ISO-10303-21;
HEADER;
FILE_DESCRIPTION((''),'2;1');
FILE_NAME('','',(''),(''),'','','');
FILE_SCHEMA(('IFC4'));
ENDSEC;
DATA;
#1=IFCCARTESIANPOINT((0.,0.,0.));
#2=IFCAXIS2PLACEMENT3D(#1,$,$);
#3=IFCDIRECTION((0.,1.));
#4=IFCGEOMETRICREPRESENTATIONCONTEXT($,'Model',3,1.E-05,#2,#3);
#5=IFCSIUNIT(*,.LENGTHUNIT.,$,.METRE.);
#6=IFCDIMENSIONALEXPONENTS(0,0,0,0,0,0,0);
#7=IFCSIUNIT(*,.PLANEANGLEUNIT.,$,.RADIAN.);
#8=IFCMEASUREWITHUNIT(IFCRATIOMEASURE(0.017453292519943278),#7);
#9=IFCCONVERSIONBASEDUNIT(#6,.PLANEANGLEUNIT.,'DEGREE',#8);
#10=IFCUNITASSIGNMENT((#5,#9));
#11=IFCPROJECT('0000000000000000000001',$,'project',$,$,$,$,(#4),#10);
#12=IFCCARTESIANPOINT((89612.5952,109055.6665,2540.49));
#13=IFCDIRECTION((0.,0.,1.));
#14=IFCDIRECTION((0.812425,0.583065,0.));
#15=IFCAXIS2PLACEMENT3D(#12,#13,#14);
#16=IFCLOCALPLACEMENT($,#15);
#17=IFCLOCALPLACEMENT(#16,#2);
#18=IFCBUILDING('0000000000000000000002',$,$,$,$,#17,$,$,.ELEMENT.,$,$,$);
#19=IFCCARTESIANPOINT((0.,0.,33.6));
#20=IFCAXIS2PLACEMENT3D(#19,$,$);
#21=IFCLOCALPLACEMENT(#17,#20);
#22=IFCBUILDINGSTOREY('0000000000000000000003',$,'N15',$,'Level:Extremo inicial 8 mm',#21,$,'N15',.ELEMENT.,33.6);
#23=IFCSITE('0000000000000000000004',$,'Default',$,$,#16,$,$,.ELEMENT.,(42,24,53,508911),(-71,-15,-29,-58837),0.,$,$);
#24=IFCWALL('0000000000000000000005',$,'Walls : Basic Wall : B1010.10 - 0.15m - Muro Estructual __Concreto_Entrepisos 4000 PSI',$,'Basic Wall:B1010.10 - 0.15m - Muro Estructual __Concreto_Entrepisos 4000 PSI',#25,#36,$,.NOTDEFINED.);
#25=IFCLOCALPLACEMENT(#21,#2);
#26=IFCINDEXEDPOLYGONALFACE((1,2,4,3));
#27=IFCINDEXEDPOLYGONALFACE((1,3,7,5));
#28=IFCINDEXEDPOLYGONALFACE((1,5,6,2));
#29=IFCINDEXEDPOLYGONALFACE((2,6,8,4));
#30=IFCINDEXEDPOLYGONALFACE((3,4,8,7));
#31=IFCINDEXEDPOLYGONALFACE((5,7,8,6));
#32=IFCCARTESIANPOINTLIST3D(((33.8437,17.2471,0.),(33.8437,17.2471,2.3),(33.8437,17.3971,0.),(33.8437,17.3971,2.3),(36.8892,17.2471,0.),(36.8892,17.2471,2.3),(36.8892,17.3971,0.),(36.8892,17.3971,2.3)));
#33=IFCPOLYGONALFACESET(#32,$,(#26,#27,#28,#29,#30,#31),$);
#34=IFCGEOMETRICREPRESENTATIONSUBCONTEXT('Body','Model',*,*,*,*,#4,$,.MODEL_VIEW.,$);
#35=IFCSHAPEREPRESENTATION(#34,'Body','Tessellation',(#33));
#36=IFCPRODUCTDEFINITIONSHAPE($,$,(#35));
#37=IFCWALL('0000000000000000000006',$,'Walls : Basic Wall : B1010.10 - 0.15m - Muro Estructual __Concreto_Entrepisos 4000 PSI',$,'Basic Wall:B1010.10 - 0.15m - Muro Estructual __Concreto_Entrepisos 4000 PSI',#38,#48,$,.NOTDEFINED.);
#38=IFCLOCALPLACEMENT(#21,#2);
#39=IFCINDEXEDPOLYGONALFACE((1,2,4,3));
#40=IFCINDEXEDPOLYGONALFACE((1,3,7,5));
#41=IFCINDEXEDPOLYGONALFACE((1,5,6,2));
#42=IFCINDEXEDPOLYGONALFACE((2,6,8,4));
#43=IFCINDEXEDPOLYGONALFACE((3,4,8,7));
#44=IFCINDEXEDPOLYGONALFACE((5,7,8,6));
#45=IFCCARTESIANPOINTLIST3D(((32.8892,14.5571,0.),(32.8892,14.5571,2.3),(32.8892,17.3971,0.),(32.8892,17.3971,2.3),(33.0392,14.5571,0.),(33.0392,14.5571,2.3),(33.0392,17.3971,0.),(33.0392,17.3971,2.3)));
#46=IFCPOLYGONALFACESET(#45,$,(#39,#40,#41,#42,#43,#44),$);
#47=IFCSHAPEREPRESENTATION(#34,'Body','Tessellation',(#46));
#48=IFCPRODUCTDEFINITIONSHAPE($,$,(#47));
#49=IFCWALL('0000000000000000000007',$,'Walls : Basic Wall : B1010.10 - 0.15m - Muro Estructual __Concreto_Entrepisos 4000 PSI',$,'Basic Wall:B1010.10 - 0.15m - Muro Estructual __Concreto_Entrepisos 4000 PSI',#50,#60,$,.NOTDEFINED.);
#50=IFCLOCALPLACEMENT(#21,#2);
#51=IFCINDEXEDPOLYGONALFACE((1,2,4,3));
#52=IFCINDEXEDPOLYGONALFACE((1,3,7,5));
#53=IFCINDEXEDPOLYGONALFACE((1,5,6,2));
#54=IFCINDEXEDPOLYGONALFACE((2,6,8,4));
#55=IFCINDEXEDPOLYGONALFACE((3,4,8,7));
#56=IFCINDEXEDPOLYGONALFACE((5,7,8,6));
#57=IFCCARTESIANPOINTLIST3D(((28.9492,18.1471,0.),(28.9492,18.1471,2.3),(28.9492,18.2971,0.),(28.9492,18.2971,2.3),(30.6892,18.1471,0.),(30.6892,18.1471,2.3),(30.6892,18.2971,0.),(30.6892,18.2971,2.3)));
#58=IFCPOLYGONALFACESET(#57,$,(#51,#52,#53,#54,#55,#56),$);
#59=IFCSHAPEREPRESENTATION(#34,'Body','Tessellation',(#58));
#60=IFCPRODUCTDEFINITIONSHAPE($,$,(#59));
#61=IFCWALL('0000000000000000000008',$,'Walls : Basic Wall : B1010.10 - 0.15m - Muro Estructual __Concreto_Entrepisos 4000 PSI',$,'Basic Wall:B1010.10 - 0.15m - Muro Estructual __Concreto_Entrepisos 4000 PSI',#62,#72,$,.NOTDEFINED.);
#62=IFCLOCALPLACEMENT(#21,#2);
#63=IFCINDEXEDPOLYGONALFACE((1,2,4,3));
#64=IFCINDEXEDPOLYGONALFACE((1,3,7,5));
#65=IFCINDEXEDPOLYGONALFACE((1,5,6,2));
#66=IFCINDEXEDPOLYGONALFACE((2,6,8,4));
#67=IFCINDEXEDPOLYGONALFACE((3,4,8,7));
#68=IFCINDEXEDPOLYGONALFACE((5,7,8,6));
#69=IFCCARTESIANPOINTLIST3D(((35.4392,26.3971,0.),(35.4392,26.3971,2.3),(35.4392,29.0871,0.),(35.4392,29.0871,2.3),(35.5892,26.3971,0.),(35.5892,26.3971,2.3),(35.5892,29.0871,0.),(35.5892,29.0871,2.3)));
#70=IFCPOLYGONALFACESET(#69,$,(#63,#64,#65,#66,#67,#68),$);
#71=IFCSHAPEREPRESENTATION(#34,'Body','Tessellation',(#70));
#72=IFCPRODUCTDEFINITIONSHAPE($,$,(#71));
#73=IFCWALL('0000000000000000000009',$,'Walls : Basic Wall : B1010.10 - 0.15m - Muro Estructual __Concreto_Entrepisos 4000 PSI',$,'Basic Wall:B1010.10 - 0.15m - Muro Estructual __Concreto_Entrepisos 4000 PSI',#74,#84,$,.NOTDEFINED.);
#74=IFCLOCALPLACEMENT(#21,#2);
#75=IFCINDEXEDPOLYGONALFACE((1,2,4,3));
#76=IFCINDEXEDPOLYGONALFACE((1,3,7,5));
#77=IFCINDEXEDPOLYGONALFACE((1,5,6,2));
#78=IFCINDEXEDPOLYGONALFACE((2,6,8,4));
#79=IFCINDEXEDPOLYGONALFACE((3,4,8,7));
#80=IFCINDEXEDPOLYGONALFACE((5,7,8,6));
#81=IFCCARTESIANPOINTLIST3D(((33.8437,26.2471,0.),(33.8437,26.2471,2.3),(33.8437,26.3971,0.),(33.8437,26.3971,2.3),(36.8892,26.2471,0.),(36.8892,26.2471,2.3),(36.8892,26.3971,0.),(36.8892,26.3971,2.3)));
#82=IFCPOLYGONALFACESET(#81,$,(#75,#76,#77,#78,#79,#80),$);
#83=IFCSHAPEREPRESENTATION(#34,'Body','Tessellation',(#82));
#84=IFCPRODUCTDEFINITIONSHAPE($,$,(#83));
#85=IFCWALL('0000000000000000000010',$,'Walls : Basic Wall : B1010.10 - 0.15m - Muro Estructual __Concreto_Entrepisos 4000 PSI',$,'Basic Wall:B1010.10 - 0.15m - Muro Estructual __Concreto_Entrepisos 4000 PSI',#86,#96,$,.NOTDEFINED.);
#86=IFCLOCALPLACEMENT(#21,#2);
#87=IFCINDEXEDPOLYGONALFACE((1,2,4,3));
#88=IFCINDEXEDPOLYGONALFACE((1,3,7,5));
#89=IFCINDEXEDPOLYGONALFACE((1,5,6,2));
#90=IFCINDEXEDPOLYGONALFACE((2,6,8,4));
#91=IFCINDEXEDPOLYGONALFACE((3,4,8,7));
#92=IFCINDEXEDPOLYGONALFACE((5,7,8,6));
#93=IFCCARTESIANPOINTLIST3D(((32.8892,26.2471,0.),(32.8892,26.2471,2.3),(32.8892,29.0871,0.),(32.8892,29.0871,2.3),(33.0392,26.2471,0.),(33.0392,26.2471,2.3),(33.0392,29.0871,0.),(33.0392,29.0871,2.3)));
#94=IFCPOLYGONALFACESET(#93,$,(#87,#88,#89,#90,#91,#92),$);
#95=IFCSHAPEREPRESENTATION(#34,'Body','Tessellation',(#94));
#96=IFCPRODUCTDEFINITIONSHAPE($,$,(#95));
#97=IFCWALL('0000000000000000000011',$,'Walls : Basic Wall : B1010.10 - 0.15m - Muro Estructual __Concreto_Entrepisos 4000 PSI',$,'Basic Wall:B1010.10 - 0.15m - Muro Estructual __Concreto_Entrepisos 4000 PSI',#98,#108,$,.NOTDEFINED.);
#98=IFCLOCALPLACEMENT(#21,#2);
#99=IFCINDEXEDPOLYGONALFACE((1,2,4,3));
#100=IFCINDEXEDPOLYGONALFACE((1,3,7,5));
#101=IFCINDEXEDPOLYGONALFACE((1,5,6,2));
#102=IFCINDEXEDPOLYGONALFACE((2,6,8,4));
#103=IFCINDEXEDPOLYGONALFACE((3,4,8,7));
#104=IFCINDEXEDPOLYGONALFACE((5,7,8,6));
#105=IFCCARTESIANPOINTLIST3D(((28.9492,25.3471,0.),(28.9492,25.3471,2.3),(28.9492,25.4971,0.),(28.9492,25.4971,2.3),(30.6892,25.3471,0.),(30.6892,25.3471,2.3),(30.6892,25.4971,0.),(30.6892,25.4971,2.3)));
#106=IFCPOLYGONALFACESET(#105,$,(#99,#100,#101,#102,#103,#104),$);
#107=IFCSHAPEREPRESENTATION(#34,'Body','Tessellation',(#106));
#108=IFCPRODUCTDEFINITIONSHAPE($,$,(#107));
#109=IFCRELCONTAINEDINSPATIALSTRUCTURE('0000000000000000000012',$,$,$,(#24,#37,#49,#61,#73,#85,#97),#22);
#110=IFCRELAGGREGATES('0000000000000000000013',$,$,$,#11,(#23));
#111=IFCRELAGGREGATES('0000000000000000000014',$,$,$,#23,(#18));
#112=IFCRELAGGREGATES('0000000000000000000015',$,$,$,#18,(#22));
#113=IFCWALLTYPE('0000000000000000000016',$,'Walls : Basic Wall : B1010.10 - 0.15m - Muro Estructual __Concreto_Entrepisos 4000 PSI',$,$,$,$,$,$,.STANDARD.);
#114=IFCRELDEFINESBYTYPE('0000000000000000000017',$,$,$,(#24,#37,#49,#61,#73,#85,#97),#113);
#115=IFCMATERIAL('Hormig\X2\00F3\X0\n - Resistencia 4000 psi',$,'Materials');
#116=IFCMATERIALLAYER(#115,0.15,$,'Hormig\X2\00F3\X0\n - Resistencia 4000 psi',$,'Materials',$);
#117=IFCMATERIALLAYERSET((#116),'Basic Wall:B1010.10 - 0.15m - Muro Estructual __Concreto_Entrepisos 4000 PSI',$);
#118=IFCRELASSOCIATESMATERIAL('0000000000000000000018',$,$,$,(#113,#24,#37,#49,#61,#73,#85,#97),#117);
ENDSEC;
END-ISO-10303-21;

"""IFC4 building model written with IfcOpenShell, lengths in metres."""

from ifc_helpers import new_model, entity, si_unit, converted_unit, direction, frame, frame_2d, origin, place, context, subcontext, project, spatial, rectangle, extrude, material, layer, layer_set, layer_usage, type_object, element, save


model = new_model("IFC4")

# Units and contexts
model_context = context("Model", 3, precision=1e-05, world=origin(), true_north=direction((0.0, 1.0)))
body_context = subcontext(model_context, "Body", "Model", "MODEL_VIEW")
ifc_project = project(units=[si_unit("LENGTHUNIT", "METRE"), converted_unit("PLANEANGLEUNIT", "DEGREE", entity("IfcRatioMeasure", 0.017453292519943278), si_unit("PLANEANGLEUNIT", "RADIAN"), dimensions=[0, 0, 0, 0, 0, 0, 0])], contexts=[model_context])

# Site, building, storey
site_placement = place(None, frame((89612.5952, 109055.6665, 2540.49), z_axis=(0.0, 0.0, 1.0), x_axis=(0.812425, 0.583065, 0.0)))
site = spatial("IfcSite", under=ifc_project, at=site_placement, Name="Default", CompositionType="ELEMENT", RefLatitude=(42, 24, 53, 508911), RefLongitude=(-71, -15, -29, -58837), RefElevation=0.0)
building_placement = place(site_placement, origin())
building = spatial("IfcBuilding", under=site, at=building_placement, CompositionType="ELEMENT")
storey_placement = place(building_placement, frame((0.0, 0.0, 33.6)))
storey = spatial("IfcBuildingStorey", under=building, at=storey_placement, Name="N15", ObjectType="Level:Extremo inicial 8 mm", LongName="N15", CompositionType="ELEMENT", Elevation=33.6)

# Walls
ifc_material = material(Name="Hormigón - Resistencia 4000 psi", Category="Materials")
ifc_layer_1 = layer(ifc_material, 0.15, Name="Hormigón - Resistencia 4000 psi", Category="Materials")
ifc_layer_set_1 = layer_set([ifc_layer_1], Name="Basic Wall:B1010.10 - 0.15m - Muro Estructual __Concreto_Entrepisos 4000 PSI")
wall_type_1 = type_object("IfcWallType", Name="Walls : Basic Wall : B1010.10 - 0.15m - Muro Estructual __Concreto_Entrepisos 4000 PSI", PredefinedType="STANDARD", material=ifc_layer_set_1)
ifc_layer_usage_1 = layer_usage(ifc_layer_set_1, "AXIS2", "NEGATIVE", 0.075)
wall_1_placement = place(storey_placement, frame((36.8892, 17.3221, 0.0), z_axis=(0.0, 0.0, 1.0), x_axis=(-1.0, 0.0, 0.0)))
element("IfcWall", 1, at=wall_1_placement, inside=storey, type_object=wall_type_1, material=ifc_layer_usage_1, Name="Walls : Basic Wall : B1010.10 - 0.15m - Muro Estructual __Concreto_Entrepisos 4000 PSI", ObjectType="Basic Wall:B1010.10 - 0.15m - Muro Estructual __Concreto_Entrepisos 4000 PSI", PredefinedType="NOTDEFINED", context=body_context, shape_type="SweptSolid", body=[
    extrude(rectangle(XDim=3.0455, YDim=0.15, at=frame_2d((1.5228, 0.0), x_axis=(-1.0, 0.0))), origin(), (0.0, 0.0, 1.0), 2.3),
])
ifc_layer_usage_2 = layer_usage(ifc_layer_set_1, "AXIS2", "NEGATIVE", 0.075)
wall_2_placement = place(storey_placement, frame((32.9642, 14.5571, 0.0), z_axis=(0.0, 0.0, 1.0), x_axis=(0.0, 1.0, 0.0)))
element("IfcWall", 2, at=wall_2_placement, inside=storey, type_object=wall_type_1, material=ifc_layer_usage_2, Name="Walls : Basic Wall : B1010.10 - 0.15m - Muro Estructual __Concreto_Entrepisos 4000 PSI", ObjectType="Basic Wall:B1010.10 - 0.15m - Muro Estructual __Concreto_Entrepisos 4000 PSI", PredefinedType="NOTDEFINED", context=body_context, shape_type="SweptSolid", body=[
    extrude(rectangle(XDim=2.84, YDim=0.15, at=frame_2d((1.42, 0.0), x_axis=(-1.0, 0.0))), origin(), (0.0, 0.0, 1.0), 2.3),
])
ifc_layer_usage_3 = layer_usage(ifc_layer_set_1, "AXIS2", "NEGATIVE", 0.075)
wall_3_placement = place(storey_placement, frame((30.6892, 18.2221, 0.0), z_axis=(0.0, 0.0, 1.0), x_axis=(-1.0, 0.0, 0.0)))
element("IfcWall", 3, at=wall_3_placement, inside=storey, type_object=wall_type_1, material=ifc_layer_usage_3, Name="Walls : Basic Wall : B1010.10 - 0.15m - Muro Estructual __Concreto_Entrepisos 4000 PSI", ObjectType="Basic Wall:B1010.10 - 0.15m - Muro Estructual __Concreto_Entrepisos 4000 PSI", PredefinedType="NOTDEFINED", context=body_context, shape_type="SweptSolid", body=[
    extrude(rectangle(XDim=1.74, YDim=0.15, at=frame_2d((0.87, 0.0), x_axis=(-1.0, 0.0))), origin(), (0.0, 0.0, 1.0), 2.3),
])
ifc_layer_usage_4 = layer_usage(ifc_layer_set_1, "AXIS2", "POSITIVE", -0.075)
wall_4_placement = place(storey_placement, frame((35.5142, 29.0871, 0.0), z_axis=(0.0, 0.0, 1.0), x_axis=(0.0, -1.0, 0.0)))
element("IfcWall", 4, at=wall_4_placement, inside=storey, type_object=wall_type_1, material=ifc_layer_usage_4, Name="Walls : Basic Wall : B1010.10 - 0.15m - Muro Estructual __Concreto_Entrepisos 4000 PSI", ObjectType="Basic Wall:B1010.10 - 0.15m - Muro Estructual __Concreto_Entrepisos 4000 PSI", PredefinedType="NOTDEFINED", context=body_context, shape_type="SweptSolid", body=[
    extrude(rectangle(XDim=2.69, YDim=0.15, at=frame_2d((1.345, 0.0), x_axis=(-1.0, 0.0))), origin(), (0.0, 0.0, 1.0), 2.3),
])
ifc_layer_usage_5 = layer_usage(ifc_layer_set_1, "AXIS2", "POSITIVE", -0.075)
wall_5_placement = place(storey_placement, frame((36.8892, 26.3221, 0.0), z_axis=(0.0, 0.0, 1.0), x_axis=(-1.0, 0.0, 0.0)))
element("IfcWall", 5, at=wall_5_placement, inside=storey, type_object=wall_type_1, material=ifc_layer_usage_5, Name="Walls : Basic Wall : B1010.10 - 0.15m - Muro Estructual __Concreto_Entrepisos 4000 PSI", ObjectType="Basic Wall:B1010.10 - 0.15m - Muro Estructual __Concreto_Entrepisos 4000 PSI", PredefinedType="NOTDEFINED", context=body_context, shape_type="SweptSolid", body=[
    extrude(rectangle(XDim=3.0455, YDim=0.15, at=frame_2d((1.5228, 0.0), x_axis=(-1.0, 0.0))), origin(), (0.0, 0.0, 1.0), 2.3),
])
ifc_layer_usage_6 = layer_usage(ifc_layer_set_1, "AXIS2", "POSITIVE", -0.075)
wall_6_placement = place(storey_placement, frame((32.9642, 29.0871, 0.0), z_axis=(0.0, 0.0, 1.0), x_axis=(0.0, -1.0, 0.0)))
element("IfcWall", 6, at=wall_6_placement, inside=storey, type_object=wall_type_1, material=ifc_layer_usage_6, Name="Walls : Basic Wall : B1010.10 - 0.15m - Muro Estructual __Concreto_Entrepisos 4000 PSI", ObjectType="Basic Wall:B1010.10 - 0.15m - Muro Estructual __Concreto_Entrepisos 4000 PSI", PredefinedType="NOTDEFINED", context=body_context, shape_type="SweptSolid", body=[
    extrude(rectangle(XDim=2.84, YDim=0.15, at=frame_2d((1.42, 0.0), x_axis=(-1.0, 0.0))), origin(), (0.0, 0.0, 1.0), 2.3),
])
ifc_layer_usage_7 = layer_usage(ifc_layer_set_1, "AXIS2", "POSITIVE", -0.075)
wall_7_placement = place(storey_placement, frame((30.6892, 25.4221, 0.0), z_axis=(0.0, 0.0, 1.0), x_axis=(-1.0, 0.0, 0.0)))
element("IfcWall", 7, at=wall_7_placement, inside=storey, type_object=wall_type_1, material=ifc_layer_usage_7, Name="Walls : Basic Wall : B1010.10 - 0.15m - Muro Estructual __Concreto_Entrepisos 4000 PSI", ObjectType="Basic Wall:B1010.10 - 0.15m - Muro Estructual __Concreto_Entrepisos 4000 PSI", PredefinedType="NOTDEFINED", context=body_context, shape_type="SweptSolid", body=[
    extrude(rectangle(XDim=1.74, YDim=0.15, at=frame_2d((0.87, 0.0), x_axis=(-1.0, 0.0))), origin(), (0.0, 0.0, 1.0), 2.3),
])

save(model, "model.ifc")
